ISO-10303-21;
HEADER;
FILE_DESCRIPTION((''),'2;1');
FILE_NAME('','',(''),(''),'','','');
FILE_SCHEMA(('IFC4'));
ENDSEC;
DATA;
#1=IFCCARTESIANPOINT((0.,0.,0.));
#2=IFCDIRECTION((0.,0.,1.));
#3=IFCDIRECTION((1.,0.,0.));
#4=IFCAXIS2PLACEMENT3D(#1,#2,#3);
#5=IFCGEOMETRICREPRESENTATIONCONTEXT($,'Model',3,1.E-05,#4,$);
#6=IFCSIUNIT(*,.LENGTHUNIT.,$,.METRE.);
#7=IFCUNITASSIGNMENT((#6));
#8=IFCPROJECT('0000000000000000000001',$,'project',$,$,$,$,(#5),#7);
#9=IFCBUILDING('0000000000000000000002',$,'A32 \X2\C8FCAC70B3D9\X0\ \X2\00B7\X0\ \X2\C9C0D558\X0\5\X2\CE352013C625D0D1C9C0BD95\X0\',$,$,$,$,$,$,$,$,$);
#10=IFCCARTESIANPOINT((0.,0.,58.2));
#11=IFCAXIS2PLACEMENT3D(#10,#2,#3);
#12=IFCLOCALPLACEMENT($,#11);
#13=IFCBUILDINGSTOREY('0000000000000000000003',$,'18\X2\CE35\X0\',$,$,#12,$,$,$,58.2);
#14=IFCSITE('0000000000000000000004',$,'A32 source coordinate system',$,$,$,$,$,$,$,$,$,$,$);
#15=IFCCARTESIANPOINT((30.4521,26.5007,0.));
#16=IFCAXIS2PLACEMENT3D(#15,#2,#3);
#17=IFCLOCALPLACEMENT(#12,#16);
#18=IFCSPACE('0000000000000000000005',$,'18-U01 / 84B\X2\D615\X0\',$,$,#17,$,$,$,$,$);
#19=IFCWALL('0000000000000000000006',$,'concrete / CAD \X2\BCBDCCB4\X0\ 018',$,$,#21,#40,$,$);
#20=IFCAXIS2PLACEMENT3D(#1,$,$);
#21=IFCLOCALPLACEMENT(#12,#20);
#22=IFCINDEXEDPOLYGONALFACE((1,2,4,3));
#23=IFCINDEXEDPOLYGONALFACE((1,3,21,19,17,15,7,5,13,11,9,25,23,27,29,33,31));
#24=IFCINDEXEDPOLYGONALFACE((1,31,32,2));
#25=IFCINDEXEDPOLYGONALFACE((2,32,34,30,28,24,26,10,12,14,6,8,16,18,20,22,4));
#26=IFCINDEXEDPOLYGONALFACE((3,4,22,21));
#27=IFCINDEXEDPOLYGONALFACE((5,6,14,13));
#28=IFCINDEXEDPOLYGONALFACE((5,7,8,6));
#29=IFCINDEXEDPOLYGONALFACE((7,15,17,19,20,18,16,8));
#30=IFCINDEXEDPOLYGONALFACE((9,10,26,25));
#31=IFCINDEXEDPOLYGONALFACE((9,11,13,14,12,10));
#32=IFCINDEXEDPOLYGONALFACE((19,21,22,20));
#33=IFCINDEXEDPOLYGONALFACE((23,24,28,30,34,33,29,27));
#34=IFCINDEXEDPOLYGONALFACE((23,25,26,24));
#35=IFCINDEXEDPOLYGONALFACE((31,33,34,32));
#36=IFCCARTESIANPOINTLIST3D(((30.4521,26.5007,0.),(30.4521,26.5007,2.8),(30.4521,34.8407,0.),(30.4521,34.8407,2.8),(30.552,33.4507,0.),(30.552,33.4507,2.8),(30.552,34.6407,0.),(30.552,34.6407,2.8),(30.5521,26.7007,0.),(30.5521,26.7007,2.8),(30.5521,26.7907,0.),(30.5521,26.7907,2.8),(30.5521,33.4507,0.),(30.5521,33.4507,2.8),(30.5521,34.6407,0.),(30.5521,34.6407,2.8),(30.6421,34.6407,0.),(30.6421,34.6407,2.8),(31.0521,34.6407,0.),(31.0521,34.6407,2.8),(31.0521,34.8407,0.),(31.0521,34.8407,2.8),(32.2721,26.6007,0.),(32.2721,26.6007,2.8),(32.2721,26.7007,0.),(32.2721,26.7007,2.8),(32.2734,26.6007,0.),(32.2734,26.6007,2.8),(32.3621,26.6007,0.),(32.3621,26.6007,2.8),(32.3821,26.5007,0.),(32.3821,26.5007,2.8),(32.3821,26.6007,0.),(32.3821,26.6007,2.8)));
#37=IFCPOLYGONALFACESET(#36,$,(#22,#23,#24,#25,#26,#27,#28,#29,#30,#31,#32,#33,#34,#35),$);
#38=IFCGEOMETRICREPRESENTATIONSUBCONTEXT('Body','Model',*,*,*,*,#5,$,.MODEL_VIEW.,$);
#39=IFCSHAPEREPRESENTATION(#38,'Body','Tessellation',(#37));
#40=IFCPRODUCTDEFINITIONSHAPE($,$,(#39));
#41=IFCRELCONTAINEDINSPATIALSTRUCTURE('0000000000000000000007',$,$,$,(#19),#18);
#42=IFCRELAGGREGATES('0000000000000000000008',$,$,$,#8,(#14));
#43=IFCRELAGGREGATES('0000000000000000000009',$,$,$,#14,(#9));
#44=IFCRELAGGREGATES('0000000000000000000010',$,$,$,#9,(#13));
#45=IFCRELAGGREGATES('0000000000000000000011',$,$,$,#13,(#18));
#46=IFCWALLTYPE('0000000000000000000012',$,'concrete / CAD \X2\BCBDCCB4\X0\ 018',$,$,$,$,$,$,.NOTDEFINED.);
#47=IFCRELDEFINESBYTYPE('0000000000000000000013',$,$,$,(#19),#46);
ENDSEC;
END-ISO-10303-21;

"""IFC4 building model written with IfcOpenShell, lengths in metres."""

from ifc_helpers import new_model, si_unit, frame, origin, origin_with_axes, place, context, subcontext, project, spatial, polyline, outline, extrude, source, transform, mapped, type_object, type_shapes, element, save


model = new_model("IFC4")

# Units and contexts
model_context = context("Model", 3, precision=1e-05, world=origin_with_axes())
body_context = subcontext(model_context, "Body", "Model", "MODEL_VIEW")
ifc_project = project(units=[si_unit("LENGTHUNIT", "METRE")], contexts=[model_context])

# Site, building, storey, space
site = spatial("IfcSite", under=ifc_project, Name="A32 source coordinate system")
building = spatial("IfcBuilding", under=site, Name="A32 주거동 · 지하5층–옥탑지붕")
storey_placement = place(None, frame((0.0, 0.0, 58.2), z_axis=(0.0, 0.0, 1.0), x_axis=(1.0, 0.0, 0.0)))
storey = spatial("IfcBuildingStorey", under=building, at=storey_placement, Name="18층", Elevation=58.2)
space_1_placement = place(storey_placement, frame((30.4521, 26.5007, 0.0), z_axis=(0.0, 0.0, 1.0), x_axis=(1.0, 0.0, 0.0)))
space_1 = spatial("IfcSpace", under=storey, at=space_1_placement, Name="18-U01 / 84B형")

# Wall
wall_type_1 = type_object("IfcWallType", Name="concrete / CAD 벽체 018", PredefinedType="NOTDEFINED")
shared_shape_1 = source(origin(), body_context, "Body", "SweptSolid", [
    extrude(outline(polyline([(0.6, 8.34), (0.6, 8.14), (0.19, 8.14), (0.1, 8.14), (0.0999, 8.14), (0.0999, 6.95), (0.1, 6.95), (0.1, 0.29), (0.1, 0.2), (1.82, 0.2), (1.82, 0.1), (1.8213, 0.1), (1.91, 0.1), (1.93, 0.1), (1.93, 0.0), (0.0, 0.0), (0.0, 8.34), (-0.35, 8.34), (-0.35, 8.34), (0.6, 8.34)])), origin(), (0.0, 0.0, 1.0), 2.8),
])
type_shapes(wall_type_1, [shared_shape_1])
wall_1_placement = place(space_1_placement, origin_with_axes())
element("IfcWall", 1, at=wall_1_placement, inside=space_1, type_object=wall_type_1, Name="concrete / CAD 벽체 018", context=body_context, shape_type="MappedRepresentation", body=[
    mapped(shared_shape_1, transform((0.0, 0.0, 0.0), scale=1.0)),
])

save(model, "model.ifc")
